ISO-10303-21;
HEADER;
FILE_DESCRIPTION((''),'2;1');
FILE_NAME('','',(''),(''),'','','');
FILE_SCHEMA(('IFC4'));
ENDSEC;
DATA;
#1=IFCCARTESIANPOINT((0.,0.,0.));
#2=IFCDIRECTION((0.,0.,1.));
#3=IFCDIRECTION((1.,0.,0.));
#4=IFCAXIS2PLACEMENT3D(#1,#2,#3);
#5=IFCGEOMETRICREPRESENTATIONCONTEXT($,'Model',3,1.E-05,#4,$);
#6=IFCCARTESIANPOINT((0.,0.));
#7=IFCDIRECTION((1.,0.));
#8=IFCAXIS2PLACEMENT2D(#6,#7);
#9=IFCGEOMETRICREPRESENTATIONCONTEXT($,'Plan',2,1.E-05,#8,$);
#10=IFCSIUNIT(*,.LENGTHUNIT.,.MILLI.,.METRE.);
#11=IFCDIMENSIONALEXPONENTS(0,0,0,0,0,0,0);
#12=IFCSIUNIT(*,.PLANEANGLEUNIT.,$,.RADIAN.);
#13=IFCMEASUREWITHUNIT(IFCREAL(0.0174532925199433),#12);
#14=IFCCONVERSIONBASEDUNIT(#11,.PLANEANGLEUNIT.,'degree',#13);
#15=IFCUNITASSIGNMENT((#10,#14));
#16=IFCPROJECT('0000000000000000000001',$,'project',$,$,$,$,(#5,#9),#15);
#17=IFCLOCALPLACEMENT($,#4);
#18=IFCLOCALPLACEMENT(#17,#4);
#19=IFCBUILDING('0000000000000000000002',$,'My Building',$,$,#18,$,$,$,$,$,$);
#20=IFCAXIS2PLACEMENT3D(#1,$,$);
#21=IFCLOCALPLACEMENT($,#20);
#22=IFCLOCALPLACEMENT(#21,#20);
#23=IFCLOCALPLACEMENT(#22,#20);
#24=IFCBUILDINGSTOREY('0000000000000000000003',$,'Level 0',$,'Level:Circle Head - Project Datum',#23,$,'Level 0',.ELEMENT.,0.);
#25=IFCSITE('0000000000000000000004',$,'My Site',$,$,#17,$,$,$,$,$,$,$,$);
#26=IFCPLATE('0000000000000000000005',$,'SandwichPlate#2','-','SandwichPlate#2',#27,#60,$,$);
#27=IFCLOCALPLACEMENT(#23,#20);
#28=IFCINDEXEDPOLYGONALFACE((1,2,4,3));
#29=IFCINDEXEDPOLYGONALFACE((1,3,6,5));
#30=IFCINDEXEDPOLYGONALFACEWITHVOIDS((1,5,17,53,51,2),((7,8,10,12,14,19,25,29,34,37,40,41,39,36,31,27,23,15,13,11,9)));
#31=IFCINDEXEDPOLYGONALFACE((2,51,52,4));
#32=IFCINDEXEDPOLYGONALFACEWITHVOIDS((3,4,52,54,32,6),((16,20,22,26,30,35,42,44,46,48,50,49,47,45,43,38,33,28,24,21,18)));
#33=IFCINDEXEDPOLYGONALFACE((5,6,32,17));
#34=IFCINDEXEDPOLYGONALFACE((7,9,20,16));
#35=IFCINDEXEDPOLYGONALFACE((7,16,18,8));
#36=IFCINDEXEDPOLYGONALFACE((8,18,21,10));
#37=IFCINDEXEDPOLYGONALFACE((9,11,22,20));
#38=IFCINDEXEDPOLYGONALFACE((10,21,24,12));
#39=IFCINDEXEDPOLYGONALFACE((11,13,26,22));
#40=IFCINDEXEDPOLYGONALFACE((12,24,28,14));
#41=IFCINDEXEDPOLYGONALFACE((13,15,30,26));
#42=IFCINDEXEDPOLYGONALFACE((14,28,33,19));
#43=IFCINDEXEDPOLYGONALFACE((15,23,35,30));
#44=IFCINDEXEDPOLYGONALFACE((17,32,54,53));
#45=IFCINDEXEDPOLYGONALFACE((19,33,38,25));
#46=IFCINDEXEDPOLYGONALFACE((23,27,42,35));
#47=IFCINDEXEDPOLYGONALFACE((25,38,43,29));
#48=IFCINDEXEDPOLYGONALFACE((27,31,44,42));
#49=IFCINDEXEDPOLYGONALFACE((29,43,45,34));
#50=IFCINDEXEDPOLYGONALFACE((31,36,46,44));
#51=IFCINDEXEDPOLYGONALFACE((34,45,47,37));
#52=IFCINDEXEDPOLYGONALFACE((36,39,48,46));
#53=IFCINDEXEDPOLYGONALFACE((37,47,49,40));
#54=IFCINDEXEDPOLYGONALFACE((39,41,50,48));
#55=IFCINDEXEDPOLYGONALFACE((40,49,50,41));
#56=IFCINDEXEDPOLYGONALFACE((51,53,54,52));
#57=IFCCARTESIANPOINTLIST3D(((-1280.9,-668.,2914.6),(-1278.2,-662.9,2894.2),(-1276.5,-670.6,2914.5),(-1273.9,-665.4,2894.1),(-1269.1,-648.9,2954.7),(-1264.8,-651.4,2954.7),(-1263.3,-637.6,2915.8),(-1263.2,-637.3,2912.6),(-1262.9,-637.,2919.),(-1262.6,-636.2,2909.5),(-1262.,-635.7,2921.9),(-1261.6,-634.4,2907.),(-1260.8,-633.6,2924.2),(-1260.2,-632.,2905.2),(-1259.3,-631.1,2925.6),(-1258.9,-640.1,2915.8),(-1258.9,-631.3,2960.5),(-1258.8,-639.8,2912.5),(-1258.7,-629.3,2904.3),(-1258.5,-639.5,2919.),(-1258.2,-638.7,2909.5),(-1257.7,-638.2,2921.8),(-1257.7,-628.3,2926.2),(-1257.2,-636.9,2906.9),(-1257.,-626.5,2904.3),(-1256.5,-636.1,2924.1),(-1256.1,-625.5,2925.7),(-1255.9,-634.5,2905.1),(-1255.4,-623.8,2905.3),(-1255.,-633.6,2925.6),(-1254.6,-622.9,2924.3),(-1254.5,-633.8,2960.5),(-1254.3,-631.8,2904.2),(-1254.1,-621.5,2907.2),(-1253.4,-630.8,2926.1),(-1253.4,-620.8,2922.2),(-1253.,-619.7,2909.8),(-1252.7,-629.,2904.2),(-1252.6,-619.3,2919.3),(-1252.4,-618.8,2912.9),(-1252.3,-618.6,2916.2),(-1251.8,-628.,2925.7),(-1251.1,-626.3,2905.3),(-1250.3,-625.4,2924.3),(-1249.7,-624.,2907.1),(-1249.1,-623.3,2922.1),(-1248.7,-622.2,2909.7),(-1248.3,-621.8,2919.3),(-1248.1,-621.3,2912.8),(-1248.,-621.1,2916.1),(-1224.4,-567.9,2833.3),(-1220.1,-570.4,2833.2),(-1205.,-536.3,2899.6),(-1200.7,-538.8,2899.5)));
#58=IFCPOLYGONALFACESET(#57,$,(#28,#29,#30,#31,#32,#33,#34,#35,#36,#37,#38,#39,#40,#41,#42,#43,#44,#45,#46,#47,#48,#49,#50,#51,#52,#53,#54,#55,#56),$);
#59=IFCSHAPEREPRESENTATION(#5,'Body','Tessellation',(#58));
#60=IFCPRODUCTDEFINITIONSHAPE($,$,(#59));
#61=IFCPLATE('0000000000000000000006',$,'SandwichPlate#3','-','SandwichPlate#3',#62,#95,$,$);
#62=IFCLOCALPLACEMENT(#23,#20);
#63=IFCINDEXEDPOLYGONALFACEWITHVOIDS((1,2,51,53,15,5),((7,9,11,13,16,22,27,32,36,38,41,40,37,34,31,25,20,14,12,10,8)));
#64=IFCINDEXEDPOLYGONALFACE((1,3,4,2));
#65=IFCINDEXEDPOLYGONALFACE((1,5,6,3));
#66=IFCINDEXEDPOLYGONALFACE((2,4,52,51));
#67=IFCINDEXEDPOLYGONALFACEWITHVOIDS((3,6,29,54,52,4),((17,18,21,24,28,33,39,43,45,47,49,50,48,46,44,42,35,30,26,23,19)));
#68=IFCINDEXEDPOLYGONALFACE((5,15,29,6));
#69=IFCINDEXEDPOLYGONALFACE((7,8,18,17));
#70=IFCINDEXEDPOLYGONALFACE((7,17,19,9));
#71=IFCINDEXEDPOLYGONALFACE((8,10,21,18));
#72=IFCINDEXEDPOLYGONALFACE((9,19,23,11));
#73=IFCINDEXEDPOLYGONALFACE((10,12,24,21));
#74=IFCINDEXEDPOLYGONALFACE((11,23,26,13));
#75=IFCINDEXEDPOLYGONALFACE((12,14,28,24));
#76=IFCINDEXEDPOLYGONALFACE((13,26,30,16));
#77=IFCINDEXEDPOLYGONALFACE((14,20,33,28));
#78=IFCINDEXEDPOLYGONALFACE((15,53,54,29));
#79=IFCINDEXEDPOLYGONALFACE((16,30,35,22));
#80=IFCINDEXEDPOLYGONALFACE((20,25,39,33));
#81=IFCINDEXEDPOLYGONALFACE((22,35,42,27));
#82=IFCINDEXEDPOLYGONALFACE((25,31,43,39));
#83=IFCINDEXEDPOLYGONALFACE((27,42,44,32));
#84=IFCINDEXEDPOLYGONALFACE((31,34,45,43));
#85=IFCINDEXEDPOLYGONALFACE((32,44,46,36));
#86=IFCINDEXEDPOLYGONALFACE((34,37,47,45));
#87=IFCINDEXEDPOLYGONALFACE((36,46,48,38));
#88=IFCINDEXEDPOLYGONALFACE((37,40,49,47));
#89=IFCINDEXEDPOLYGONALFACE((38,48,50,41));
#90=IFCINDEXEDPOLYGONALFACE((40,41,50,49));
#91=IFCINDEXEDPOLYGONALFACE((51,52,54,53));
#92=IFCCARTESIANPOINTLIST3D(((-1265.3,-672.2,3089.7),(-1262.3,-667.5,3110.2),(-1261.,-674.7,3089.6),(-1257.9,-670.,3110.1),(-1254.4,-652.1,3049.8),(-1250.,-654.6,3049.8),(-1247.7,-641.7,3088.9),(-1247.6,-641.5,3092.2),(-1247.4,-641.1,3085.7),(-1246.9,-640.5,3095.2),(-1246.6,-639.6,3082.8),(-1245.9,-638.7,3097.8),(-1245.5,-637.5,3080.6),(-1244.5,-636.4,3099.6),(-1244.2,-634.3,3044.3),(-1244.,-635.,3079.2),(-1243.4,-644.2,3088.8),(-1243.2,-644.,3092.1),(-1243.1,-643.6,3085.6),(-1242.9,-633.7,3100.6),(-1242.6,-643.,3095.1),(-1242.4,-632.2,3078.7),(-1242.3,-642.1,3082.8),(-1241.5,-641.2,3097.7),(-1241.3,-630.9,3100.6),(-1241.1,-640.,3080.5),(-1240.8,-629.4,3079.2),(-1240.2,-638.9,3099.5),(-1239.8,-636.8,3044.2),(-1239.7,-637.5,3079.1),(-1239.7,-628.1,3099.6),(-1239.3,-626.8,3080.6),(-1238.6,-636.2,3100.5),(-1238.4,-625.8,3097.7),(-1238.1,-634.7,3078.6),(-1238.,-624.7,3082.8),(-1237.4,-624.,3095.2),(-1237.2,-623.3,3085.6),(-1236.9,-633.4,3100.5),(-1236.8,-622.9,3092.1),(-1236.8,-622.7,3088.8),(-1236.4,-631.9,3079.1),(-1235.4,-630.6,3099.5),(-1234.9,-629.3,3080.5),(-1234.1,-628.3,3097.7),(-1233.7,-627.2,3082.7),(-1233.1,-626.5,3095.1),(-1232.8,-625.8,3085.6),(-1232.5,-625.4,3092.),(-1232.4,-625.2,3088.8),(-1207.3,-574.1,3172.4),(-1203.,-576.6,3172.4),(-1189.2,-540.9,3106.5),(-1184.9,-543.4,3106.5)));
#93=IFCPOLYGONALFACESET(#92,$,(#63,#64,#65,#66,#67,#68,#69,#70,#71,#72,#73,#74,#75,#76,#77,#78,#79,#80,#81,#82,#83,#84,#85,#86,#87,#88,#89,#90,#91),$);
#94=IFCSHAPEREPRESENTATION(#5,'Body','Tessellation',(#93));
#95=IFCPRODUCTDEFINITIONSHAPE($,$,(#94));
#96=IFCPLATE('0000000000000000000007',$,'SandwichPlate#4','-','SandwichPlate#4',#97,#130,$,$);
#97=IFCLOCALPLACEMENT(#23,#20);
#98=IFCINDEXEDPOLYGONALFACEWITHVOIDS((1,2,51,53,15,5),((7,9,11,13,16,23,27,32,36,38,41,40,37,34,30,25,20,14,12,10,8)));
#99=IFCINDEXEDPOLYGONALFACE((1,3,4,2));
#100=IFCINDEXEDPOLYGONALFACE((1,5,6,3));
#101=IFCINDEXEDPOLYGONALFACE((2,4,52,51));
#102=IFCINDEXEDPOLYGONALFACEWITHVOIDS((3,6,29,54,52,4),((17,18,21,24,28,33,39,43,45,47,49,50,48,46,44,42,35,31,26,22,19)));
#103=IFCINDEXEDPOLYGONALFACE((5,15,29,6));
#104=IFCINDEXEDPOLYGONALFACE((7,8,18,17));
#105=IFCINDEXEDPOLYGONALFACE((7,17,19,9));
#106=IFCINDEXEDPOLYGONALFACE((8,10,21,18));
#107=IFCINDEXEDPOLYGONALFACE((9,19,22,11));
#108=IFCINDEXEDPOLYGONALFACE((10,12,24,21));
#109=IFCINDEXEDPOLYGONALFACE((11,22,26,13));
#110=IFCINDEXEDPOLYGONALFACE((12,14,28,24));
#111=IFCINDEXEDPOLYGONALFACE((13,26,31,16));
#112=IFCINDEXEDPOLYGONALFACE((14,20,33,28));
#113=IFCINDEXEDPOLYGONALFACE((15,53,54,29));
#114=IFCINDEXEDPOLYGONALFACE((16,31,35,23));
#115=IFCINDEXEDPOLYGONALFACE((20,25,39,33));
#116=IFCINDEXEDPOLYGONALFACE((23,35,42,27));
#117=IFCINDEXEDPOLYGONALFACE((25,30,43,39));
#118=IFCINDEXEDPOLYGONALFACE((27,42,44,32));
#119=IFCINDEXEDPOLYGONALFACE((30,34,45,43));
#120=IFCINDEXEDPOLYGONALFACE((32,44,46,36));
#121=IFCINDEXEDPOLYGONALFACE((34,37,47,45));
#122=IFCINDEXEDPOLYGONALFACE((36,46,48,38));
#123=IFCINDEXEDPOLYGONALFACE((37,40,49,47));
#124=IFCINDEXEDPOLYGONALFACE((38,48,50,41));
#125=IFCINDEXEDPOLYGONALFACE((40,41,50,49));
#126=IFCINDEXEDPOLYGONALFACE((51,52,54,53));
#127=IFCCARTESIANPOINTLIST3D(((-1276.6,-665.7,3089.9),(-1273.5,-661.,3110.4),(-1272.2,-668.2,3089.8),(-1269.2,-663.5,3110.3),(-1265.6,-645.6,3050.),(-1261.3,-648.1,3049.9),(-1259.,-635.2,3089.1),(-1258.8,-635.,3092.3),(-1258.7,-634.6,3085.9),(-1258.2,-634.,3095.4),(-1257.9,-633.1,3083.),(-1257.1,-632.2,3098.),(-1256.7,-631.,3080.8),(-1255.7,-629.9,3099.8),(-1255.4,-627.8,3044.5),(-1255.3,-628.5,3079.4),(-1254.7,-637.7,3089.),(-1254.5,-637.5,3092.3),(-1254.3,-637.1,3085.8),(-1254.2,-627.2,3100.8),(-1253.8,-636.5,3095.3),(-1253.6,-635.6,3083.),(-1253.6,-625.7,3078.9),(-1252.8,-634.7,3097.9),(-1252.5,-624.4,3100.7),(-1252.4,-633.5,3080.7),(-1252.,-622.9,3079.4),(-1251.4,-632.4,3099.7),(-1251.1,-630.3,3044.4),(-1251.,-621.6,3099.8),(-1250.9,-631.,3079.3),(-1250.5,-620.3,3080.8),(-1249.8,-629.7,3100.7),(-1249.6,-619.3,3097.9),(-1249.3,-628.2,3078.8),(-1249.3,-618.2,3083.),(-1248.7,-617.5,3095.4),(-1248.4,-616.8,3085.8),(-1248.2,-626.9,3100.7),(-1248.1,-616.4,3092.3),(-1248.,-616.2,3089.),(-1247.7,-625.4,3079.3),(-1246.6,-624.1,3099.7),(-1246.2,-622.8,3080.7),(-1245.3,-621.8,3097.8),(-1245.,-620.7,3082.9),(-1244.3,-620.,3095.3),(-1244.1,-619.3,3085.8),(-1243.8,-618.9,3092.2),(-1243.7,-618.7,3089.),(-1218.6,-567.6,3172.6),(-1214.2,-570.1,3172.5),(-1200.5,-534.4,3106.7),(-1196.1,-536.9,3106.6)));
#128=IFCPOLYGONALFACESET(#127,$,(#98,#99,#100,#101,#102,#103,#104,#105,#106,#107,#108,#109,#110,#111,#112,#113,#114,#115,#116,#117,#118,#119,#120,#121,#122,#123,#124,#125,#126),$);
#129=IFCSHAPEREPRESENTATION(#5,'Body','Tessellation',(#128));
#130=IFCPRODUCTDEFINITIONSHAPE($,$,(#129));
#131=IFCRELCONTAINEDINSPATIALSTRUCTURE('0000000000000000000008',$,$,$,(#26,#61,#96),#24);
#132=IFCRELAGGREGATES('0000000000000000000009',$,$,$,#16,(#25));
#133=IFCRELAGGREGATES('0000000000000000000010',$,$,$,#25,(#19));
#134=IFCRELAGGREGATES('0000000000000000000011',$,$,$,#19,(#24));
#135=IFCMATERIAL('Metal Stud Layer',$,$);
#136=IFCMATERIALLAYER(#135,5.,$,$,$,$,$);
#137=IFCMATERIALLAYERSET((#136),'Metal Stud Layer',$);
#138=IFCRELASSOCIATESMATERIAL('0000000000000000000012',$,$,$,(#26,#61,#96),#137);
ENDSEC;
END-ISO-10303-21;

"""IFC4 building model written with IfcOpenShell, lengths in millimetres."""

from ifc_helpers import new_model, entity, si_unit, converted_unit, frame, origin, origin_with_axes, origin_2d_with_axis, place, context, project, spatial, polyline, circle, outline, extrude, material, layer, layer_set, element, save


model = new_model("IFC4")

# Units and contexts
model_context = context("Model", 3, precision=1e-05, world=origin_with_axes())
plan_context = context("Plan", 2, precision=1e-05, world=origin_2d_with_axis())
ifc_project = project(units=[si_unit("LENGTHUNIT", "METRE", prefix="MILLI"), converted_unit("PLANEANGLEUNIT", "degree", entity("IfcReal", 0.0174532925199433), si_unit("PLANEANGLEUNIT", "RADIAN"), dimensions=[0, 0, 0, 0, 0, 0, 0])], contexts=[model_context, plan_context])

# Site, building, storey
site_placement = place(None, origin_with_axes())
site = spatial("IfcSite", under=ifc_project, at=site_placement, Name="My Site")
building_placement = place(site_placement, origin_with_axes())
building = spatial("IfcBuilding", under=site, at=building_placement, Name="My Building")
placement_1 = place(None, origin())
placement_2 = place(placement_1, origin())
storey_placement = place(placement_2, origin())
storey = spatial("IfcBuildingStorey", under=building, at=storey_placement, Name="Level 0", ObjectType="Level:Circle Head - Project Datum", LongName="Level 0", CompositionType="ELEMENT", Elevation=0.0)

# Plates, openings
ifc_material = material(Name="Metal Stud Layer")
ifc_layer_1 = layer(ifc_material, 5.0)
ifc_layer_set_1 = layer_set([ifc_layer_1], Name="Metal Stud Layer")
plate_1_placement = place(storey_placement, frame((-1280.3, -676.8, 2901.4), z_axis=(-0.865935, 0.499948, 0.014432), x_axis=(0.254617, 0.415806, 0.873084)))
plate_1 = element("IfcPlate", 1, at=plate_1_placement, inside=storey, material=ifc_layer_set_1, Name="SandwichPlate#2", Description="-", ObjectType="SandwichPlate#2", context=model_context, shape_type="SweptSolid", body=[
    extrude(outline(polyline([(0.0, 0.0), (76.0, 0.0), (76.0, 140.0), (0.0, 140.0), (0.0, 0.0)])), origin_with_axes(), (0.0, 0.0, 1.0), 5.0),
])
opening_1_placement = place(plate_1_placement, frame((38.0, 40.0, -0.5), z_axis=(0.0, 0.0, 1.0), x_axis=(0.0, 1.0, 0.0)))
element("IfcOpeningElement", 2, at=opening_1_placement, cuts=plate_1, ObjectType="Opening", context=model_context, shape_type="SweptSolid", body=[
    extrude(circle(Radius=11.0, at=origin_2d_with_axis()), origin(), (0.0, 0.0, 1.0), 6.0),
])
opening_2_placement = place(plate_1_placement, frame((0.0, 0.0, 0.0), z_axis=(0.0, 0.0, 1.0), x_axis=(1.0, 0.0, 0.0)))
element("IfcOpeningElement", 3, at=opening_2_placement, cuts=plate_1, ObjectType="Opening", context=model_context, shape_type="SweptSolid", body=[
    extrude(outline(polyline([(0.0, 0.0), (15.0, 0.0), (0.0, 15.0), (0.0, 0.0)])), origin(), (0.0, 0.0, 1.0), 5.0),
])
opening_3_placement = place(plate_1_placement, frame((0.0, 0.0, 0.0), z_axis=(0.0, 0.0, 1.0), x_axis=(1.0, 0.0, 0.0)))
element("IfcOpeningElement", 4, at=opening_3_placement, cuts=plate_1, ObjectType="Opening", context=model_context, shape_type="SweptSolid", body=[
    extrude(outline(polyline([(76.0, 0.0), (76.0, 15.0), (61.0, 0.0), (76.0, 0.0)])), origin(), (0.0, 0.0, 1.0), 5.0),
])
plate_2_placement = place(storey_placement, frame((-1246.4, -648.0, 3036.7), z_axis=(-0.865935, 0.499948, 0.014432), x_axis=(-0.238139, -0.437501, 0.867112)))
plate_2 = element("IfcPlate", 5, at=plate_2_placement, inside=storey, material=ifc_layer_set_1, Name="SandwichPlate#3", Description="-", ObjectType="SandwichPlate#3", context=model_context, shape_type="SweptSolid", body=[
    extrude(outline(polyline([(0.0, 0.0), (76.0, 0.0), (76.0, 140.0), (0.0, 140.0), (0.0, 0.0)])), origin_with_axes(), (0.0, 0.0, 1.0), 5.0),
])
opening_4_placement = place(plate_2_placement, frame((38.0, 40.0, -0.5), z_axis=(0.0, 0.0, 1.0), x_axis=(0.0, 1.0, 0.0)))
element("IfcOpeningElement", 6, at=opening_4_placement, cuts=plate_2, ObjectType="Opening", context=model_context, shape_type="SweptSolid", body=[
    extrude(circle(Radius=11.0, at=origin_2d_with_axis()), origin(), (0.0, 0.0, 1.0), 6.0),
])
opening_5_placement = place(plate_2_placement, frame((0.0, 0.0, 0.0), z_axis=(0.0, 0.0, 1.0), x_axis=(1.0, 0.0, 0.0)))
element("IfcOpeningElement", 7, at=opening_5_placement, cuts=plate_2, ObjectType="Opening", context=model_context, shape_type="SweptSolid", body=[
    extrude(outline(polyline([(0.0, 0.0), (15.0, 0.0), (0.0, 15.0), (0.0, 0.0)])), origin(), (0.0, 0.0, 1.0), 5.0),
])
opening_6_placement = place(plate_2_placement, frame((0.0, 0.0, 0.0), z_axis=(0.0, 0.0, 1.0), x_axis=(1.0, 0.0, 0.0)))
element("IfcOpeningElement", 8, at=opening_6_placement, cuts=plate_2, ObjectType="Opening", context=model_context, shape_type="SweptSolid", body=[
    extrude(outline(polyline([(76.0, 0.0), (76.0, 15.0), (61.0, 0.0), (76.0, 0.0)])), origin(), (0.0, 0.0, 1.0), 5.0),
])
plate_3_placement = place(storey_placement, frame((-1257.7, -641.5, 3036.9), z_axis=(-0.865935, 0.499948, 0.014432), x_axis=(-0.238139, -0.437501, 0.867112)))
plate_3 = element("IfcPlate", 9, at=plate_3_placement, inside=storey, material=ifc_layer_set_1, Name="SandwichPlate#4", Description="-", ObjectType="SandwichPlate#4", context=model_context, shape_type="SweptSolid", body=[
    extrude(outline(polyline([(0.0, 0.0), (76.0, 0.0), (76.0, 140.0), (0.0, 140.0), (0.0, 0.0)])), origin_with_axes(), (0.0, 0.0, 1.0), 5.0),
])
opening_7_placement = place(plate_3_placement, frame((38.0, 40.0, -0.5), z_axis=(0.0, 0.0, 1.0), x_axis=(0.0, 1.0, 0.0)))
element("IfcOpeningElement", 10, at=opening_7_placement, cuts=plate_3, ObjectType="Opening", context=model_context, shape_type="SweptSolid", body=[
    extrude(circle(Radius=11.0, at=origin_2d_with_axis()), origin(), (0.0, 0.0, 1.0), 6.0),
])
opening_8_placement = place(plate_3_placement, frame((0.0, 0.0, 0.0), z_axis=(0.0, 0.0, 1.0), x_axis=(1.0, 0.0, 0.0)))
element("IfcOpeningElement", 11, at=opening_8_placement, cuts=plate_3, ObjectType="Opening", context=model_context, shape_type="SweptSolid", body=[
    extrude(outline(polyline([(0.0, 0.0), (15.0, 0.0), (0.0, 15.0), (0.0, 0.0)])), origin(), (0.0, 0.0, 1.0), 5.0),
])
opening_9_placement = place(plate_3_placement, frame((0.0, 0.0, 0.0), z_axis=(0.0, 0.0, 1.0), x_axis=(1.0, 0.0, 0.0)))
element("IfcOpeningElement", 12, at=opening_9_placement, cuts=plate_3, ObjectType="Opening", context=model_context, shape_type="SweptSolid", body=[
    extrude(outline(polyline([(76.0, 0.0), (76.0, 15.0), (61.0, 0.0), (76.0, 0.0)])), origin(), (0.0, 0.0, 1.0), 5.0),
])

save(model, "model.ifc")
